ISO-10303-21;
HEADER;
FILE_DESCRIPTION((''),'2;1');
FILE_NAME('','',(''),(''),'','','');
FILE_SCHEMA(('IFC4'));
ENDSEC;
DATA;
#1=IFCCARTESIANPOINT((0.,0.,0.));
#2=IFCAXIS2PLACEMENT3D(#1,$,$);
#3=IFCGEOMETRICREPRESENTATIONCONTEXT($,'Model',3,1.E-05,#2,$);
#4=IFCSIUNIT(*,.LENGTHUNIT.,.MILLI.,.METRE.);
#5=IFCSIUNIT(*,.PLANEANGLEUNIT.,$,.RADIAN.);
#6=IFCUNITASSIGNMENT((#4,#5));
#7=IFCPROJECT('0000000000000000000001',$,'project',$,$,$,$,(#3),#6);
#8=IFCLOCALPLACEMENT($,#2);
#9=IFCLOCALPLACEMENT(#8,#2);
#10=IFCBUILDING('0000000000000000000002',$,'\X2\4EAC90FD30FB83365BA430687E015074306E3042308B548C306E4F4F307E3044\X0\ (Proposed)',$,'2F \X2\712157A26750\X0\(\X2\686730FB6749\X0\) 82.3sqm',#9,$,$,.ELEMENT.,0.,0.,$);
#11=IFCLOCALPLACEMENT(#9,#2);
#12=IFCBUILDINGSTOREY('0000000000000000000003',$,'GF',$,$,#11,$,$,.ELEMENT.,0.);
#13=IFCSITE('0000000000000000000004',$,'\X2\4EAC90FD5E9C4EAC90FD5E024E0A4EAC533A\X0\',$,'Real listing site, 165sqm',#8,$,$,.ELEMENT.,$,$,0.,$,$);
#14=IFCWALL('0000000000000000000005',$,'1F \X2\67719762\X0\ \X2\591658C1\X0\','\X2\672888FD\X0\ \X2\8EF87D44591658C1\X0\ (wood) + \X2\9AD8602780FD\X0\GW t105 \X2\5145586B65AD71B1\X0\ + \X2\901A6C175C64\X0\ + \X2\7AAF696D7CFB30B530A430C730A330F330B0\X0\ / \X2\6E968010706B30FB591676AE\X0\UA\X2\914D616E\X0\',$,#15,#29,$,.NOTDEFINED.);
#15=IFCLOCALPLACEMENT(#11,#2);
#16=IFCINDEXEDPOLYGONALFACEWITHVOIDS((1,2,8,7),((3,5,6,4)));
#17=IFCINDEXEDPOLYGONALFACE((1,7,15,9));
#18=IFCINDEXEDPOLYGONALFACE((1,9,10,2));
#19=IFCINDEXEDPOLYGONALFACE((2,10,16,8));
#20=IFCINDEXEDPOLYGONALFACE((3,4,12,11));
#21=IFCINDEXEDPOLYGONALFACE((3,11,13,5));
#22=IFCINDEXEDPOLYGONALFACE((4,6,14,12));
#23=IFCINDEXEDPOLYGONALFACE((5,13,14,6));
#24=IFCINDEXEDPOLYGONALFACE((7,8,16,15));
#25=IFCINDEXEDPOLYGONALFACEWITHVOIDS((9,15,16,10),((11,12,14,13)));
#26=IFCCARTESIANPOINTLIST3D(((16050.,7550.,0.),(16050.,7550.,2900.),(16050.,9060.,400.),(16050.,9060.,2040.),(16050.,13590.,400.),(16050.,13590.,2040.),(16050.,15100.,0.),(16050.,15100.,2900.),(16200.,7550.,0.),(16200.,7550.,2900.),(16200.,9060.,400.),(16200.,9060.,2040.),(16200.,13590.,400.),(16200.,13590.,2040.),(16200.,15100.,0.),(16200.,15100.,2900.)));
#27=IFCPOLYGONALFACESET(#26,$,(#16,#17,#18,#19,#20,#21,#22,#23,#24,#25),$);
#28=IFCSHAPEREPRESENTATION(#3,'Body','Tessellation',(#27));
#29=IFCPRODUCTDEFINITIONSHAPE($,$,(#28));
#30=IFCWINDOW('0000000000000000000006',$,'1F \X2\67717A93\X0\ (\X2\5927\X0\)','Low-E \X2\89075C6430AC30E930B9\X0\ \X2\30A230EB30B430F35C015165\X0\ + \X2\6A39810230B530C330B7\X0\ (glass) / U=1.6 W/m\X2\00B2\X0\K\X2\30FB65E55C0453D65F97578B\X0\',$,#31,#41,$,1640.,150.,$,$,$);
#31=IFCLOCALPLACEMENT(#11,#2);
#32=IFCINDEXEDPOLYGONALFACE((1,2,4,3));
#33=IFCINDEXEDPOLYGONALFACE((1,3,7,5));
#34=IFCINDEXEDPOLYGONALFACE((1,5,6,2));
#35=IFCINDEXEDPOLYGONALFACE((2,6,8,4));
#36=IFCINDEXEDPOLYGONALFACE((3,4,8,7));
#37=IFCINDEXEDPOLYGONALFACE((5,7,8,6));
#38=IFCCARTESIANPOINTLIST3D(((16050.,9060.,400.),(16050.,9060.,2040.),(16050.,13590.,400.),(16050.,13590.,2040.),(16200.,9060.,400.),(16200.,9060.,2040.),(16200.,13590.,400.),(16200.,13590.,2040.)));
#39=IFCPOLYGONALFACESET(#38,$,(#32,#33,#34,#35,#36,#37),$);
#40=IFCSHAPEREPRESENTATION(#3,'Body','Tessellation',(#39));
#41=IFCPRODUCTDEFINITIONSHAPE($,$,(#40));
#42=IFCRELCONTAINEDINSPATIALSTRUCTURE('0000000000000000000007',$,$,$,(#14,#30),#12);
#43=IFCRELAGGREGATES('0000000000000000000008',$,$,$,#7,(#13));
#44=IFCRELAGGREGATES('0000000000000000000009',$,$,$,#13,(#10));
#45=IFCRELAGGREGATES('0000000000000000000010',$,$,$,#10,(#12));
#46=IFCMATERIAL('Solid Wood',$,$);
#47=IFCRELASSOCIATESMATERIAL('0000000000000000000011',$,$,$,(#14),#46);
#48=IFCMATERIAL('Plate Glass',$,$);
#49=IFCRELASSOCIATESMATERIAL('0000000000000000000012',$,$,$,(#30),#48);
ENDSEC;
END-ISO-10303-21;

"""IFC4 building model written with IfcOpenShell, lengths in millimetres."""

from ifc_helpers import new_model, si_unit, frame, frame_2d, origin, place, context, project, spatial, rectangle, extrude, material, element, fill, save


model = new_model("IFC4")

# Units and contexts
model_context = context("Model", 3, precision=1e-05, world=origin())
ifc_project = project(units=[si_unit("LENGTHUNIT", "METRE", prefix="MILLI"), si_unit("PLANEANGLEUNIT", "RADIAN")], contexts=[model_context])

# Site, building, storey
site_placement = place(None, origin())
site = spatial("IfcSite", under=ifc_project, at=site_placement, Name="京都府京都市上京区", ObjectType="Real listing site, 165sqm", CompositionType="ELEMENT", RefElevation=0.0)
building_placement = place(site_placement, origin())
building = spatial("IfcBuilding", under=site, at=building_placement, Name="京都・茶室と縁側のある和の住まい (Proposed)", ObjectType="2F 無垢材(桧・杉) 82.3sqm", CompositionType="ELEMENT", ElevationOfRefHeight=0.0, ElevationOfTerrain=0.0)
storey_placement = place(building_placement, origin())
storey = spatial("IfcBuildingStorey", under=building, at=storey_placement, Name="GF", CompositionType="ELEMENT", Elevation=0.0)

# Shared definitions
ifc_material_1 = material(Name="Solid Wood")

# Wall, opening, window
wall_1_placement = place(storey_placement, frame((8025.0, 3775.0, 0.0)))
wall_1 = element("IfcWall", 1, at=wall_1_placement, inside=storey, material=ifc_material_1, Name="1F 東面 外壁", Description="木製 軸組外壁 (wood) + 高性能GW t105 充填断熱 + 通気層 + 窯業系サイディング / 準耐火・外皮UA配慮", PredefinedType="NOTDEFINED", context=model_context, shape_type="SweptSolid", body=[
    extrude(rectangle(XDim=150.0, YDim=7550.0, at=frame_2d((75.0, 3775.0))), frame((8025.0, 3775.0, 0.0)), (0.0, 0.0, 1.0), 2900.0),
])
opening_1_placement = place(storey_placement, frame((8025.0, 4530.0, 200.0)))
opening_1 = element("IfcOpeningElement", 2, at=opening_1_placement, cuts=wall_1, PredefinedType="NOTDEFINED", context=model_context, shape_type="SweptSolid", body=[
    extrude(rectangle(XDim=150.0, YDim=4530.0, at=frame_2d((75.0, 2265.0))), frame((8025.0, 4530.0, 200.0)), (0.0, 0.0, 1.0), 1640.0),
])
ifc_material_2 = material(Name="Plate Glass")
window_1_placement = place(storey_placement, frame((8025.0, 4530.0, 200.0)))
window_1 = element("IfcWindow", 3, at=window_1_placement, inside=storey, material=ifc_material_2, Name="1F 東窓 (大)", Description="Low-E 複層ガラス アルゴン封入 + 樹脂サッシ (glass) / U=1.6 W/m²K・日射取得型", OverallHeight=1640.0, OverallWidth=150.0, context=model_context, shape_type="SweptSolid", body=[
    extrude(rectangle(XDim=150.0, YDim=4530.0, at=frame_2d((75.0, 2265.0))), frame((8025.0, 4530.0, 200.0)), (0.0, 0.0, 1.0), 1640.0),
])
fill(opening_1, window_1)

save(model, "model.ifc")
